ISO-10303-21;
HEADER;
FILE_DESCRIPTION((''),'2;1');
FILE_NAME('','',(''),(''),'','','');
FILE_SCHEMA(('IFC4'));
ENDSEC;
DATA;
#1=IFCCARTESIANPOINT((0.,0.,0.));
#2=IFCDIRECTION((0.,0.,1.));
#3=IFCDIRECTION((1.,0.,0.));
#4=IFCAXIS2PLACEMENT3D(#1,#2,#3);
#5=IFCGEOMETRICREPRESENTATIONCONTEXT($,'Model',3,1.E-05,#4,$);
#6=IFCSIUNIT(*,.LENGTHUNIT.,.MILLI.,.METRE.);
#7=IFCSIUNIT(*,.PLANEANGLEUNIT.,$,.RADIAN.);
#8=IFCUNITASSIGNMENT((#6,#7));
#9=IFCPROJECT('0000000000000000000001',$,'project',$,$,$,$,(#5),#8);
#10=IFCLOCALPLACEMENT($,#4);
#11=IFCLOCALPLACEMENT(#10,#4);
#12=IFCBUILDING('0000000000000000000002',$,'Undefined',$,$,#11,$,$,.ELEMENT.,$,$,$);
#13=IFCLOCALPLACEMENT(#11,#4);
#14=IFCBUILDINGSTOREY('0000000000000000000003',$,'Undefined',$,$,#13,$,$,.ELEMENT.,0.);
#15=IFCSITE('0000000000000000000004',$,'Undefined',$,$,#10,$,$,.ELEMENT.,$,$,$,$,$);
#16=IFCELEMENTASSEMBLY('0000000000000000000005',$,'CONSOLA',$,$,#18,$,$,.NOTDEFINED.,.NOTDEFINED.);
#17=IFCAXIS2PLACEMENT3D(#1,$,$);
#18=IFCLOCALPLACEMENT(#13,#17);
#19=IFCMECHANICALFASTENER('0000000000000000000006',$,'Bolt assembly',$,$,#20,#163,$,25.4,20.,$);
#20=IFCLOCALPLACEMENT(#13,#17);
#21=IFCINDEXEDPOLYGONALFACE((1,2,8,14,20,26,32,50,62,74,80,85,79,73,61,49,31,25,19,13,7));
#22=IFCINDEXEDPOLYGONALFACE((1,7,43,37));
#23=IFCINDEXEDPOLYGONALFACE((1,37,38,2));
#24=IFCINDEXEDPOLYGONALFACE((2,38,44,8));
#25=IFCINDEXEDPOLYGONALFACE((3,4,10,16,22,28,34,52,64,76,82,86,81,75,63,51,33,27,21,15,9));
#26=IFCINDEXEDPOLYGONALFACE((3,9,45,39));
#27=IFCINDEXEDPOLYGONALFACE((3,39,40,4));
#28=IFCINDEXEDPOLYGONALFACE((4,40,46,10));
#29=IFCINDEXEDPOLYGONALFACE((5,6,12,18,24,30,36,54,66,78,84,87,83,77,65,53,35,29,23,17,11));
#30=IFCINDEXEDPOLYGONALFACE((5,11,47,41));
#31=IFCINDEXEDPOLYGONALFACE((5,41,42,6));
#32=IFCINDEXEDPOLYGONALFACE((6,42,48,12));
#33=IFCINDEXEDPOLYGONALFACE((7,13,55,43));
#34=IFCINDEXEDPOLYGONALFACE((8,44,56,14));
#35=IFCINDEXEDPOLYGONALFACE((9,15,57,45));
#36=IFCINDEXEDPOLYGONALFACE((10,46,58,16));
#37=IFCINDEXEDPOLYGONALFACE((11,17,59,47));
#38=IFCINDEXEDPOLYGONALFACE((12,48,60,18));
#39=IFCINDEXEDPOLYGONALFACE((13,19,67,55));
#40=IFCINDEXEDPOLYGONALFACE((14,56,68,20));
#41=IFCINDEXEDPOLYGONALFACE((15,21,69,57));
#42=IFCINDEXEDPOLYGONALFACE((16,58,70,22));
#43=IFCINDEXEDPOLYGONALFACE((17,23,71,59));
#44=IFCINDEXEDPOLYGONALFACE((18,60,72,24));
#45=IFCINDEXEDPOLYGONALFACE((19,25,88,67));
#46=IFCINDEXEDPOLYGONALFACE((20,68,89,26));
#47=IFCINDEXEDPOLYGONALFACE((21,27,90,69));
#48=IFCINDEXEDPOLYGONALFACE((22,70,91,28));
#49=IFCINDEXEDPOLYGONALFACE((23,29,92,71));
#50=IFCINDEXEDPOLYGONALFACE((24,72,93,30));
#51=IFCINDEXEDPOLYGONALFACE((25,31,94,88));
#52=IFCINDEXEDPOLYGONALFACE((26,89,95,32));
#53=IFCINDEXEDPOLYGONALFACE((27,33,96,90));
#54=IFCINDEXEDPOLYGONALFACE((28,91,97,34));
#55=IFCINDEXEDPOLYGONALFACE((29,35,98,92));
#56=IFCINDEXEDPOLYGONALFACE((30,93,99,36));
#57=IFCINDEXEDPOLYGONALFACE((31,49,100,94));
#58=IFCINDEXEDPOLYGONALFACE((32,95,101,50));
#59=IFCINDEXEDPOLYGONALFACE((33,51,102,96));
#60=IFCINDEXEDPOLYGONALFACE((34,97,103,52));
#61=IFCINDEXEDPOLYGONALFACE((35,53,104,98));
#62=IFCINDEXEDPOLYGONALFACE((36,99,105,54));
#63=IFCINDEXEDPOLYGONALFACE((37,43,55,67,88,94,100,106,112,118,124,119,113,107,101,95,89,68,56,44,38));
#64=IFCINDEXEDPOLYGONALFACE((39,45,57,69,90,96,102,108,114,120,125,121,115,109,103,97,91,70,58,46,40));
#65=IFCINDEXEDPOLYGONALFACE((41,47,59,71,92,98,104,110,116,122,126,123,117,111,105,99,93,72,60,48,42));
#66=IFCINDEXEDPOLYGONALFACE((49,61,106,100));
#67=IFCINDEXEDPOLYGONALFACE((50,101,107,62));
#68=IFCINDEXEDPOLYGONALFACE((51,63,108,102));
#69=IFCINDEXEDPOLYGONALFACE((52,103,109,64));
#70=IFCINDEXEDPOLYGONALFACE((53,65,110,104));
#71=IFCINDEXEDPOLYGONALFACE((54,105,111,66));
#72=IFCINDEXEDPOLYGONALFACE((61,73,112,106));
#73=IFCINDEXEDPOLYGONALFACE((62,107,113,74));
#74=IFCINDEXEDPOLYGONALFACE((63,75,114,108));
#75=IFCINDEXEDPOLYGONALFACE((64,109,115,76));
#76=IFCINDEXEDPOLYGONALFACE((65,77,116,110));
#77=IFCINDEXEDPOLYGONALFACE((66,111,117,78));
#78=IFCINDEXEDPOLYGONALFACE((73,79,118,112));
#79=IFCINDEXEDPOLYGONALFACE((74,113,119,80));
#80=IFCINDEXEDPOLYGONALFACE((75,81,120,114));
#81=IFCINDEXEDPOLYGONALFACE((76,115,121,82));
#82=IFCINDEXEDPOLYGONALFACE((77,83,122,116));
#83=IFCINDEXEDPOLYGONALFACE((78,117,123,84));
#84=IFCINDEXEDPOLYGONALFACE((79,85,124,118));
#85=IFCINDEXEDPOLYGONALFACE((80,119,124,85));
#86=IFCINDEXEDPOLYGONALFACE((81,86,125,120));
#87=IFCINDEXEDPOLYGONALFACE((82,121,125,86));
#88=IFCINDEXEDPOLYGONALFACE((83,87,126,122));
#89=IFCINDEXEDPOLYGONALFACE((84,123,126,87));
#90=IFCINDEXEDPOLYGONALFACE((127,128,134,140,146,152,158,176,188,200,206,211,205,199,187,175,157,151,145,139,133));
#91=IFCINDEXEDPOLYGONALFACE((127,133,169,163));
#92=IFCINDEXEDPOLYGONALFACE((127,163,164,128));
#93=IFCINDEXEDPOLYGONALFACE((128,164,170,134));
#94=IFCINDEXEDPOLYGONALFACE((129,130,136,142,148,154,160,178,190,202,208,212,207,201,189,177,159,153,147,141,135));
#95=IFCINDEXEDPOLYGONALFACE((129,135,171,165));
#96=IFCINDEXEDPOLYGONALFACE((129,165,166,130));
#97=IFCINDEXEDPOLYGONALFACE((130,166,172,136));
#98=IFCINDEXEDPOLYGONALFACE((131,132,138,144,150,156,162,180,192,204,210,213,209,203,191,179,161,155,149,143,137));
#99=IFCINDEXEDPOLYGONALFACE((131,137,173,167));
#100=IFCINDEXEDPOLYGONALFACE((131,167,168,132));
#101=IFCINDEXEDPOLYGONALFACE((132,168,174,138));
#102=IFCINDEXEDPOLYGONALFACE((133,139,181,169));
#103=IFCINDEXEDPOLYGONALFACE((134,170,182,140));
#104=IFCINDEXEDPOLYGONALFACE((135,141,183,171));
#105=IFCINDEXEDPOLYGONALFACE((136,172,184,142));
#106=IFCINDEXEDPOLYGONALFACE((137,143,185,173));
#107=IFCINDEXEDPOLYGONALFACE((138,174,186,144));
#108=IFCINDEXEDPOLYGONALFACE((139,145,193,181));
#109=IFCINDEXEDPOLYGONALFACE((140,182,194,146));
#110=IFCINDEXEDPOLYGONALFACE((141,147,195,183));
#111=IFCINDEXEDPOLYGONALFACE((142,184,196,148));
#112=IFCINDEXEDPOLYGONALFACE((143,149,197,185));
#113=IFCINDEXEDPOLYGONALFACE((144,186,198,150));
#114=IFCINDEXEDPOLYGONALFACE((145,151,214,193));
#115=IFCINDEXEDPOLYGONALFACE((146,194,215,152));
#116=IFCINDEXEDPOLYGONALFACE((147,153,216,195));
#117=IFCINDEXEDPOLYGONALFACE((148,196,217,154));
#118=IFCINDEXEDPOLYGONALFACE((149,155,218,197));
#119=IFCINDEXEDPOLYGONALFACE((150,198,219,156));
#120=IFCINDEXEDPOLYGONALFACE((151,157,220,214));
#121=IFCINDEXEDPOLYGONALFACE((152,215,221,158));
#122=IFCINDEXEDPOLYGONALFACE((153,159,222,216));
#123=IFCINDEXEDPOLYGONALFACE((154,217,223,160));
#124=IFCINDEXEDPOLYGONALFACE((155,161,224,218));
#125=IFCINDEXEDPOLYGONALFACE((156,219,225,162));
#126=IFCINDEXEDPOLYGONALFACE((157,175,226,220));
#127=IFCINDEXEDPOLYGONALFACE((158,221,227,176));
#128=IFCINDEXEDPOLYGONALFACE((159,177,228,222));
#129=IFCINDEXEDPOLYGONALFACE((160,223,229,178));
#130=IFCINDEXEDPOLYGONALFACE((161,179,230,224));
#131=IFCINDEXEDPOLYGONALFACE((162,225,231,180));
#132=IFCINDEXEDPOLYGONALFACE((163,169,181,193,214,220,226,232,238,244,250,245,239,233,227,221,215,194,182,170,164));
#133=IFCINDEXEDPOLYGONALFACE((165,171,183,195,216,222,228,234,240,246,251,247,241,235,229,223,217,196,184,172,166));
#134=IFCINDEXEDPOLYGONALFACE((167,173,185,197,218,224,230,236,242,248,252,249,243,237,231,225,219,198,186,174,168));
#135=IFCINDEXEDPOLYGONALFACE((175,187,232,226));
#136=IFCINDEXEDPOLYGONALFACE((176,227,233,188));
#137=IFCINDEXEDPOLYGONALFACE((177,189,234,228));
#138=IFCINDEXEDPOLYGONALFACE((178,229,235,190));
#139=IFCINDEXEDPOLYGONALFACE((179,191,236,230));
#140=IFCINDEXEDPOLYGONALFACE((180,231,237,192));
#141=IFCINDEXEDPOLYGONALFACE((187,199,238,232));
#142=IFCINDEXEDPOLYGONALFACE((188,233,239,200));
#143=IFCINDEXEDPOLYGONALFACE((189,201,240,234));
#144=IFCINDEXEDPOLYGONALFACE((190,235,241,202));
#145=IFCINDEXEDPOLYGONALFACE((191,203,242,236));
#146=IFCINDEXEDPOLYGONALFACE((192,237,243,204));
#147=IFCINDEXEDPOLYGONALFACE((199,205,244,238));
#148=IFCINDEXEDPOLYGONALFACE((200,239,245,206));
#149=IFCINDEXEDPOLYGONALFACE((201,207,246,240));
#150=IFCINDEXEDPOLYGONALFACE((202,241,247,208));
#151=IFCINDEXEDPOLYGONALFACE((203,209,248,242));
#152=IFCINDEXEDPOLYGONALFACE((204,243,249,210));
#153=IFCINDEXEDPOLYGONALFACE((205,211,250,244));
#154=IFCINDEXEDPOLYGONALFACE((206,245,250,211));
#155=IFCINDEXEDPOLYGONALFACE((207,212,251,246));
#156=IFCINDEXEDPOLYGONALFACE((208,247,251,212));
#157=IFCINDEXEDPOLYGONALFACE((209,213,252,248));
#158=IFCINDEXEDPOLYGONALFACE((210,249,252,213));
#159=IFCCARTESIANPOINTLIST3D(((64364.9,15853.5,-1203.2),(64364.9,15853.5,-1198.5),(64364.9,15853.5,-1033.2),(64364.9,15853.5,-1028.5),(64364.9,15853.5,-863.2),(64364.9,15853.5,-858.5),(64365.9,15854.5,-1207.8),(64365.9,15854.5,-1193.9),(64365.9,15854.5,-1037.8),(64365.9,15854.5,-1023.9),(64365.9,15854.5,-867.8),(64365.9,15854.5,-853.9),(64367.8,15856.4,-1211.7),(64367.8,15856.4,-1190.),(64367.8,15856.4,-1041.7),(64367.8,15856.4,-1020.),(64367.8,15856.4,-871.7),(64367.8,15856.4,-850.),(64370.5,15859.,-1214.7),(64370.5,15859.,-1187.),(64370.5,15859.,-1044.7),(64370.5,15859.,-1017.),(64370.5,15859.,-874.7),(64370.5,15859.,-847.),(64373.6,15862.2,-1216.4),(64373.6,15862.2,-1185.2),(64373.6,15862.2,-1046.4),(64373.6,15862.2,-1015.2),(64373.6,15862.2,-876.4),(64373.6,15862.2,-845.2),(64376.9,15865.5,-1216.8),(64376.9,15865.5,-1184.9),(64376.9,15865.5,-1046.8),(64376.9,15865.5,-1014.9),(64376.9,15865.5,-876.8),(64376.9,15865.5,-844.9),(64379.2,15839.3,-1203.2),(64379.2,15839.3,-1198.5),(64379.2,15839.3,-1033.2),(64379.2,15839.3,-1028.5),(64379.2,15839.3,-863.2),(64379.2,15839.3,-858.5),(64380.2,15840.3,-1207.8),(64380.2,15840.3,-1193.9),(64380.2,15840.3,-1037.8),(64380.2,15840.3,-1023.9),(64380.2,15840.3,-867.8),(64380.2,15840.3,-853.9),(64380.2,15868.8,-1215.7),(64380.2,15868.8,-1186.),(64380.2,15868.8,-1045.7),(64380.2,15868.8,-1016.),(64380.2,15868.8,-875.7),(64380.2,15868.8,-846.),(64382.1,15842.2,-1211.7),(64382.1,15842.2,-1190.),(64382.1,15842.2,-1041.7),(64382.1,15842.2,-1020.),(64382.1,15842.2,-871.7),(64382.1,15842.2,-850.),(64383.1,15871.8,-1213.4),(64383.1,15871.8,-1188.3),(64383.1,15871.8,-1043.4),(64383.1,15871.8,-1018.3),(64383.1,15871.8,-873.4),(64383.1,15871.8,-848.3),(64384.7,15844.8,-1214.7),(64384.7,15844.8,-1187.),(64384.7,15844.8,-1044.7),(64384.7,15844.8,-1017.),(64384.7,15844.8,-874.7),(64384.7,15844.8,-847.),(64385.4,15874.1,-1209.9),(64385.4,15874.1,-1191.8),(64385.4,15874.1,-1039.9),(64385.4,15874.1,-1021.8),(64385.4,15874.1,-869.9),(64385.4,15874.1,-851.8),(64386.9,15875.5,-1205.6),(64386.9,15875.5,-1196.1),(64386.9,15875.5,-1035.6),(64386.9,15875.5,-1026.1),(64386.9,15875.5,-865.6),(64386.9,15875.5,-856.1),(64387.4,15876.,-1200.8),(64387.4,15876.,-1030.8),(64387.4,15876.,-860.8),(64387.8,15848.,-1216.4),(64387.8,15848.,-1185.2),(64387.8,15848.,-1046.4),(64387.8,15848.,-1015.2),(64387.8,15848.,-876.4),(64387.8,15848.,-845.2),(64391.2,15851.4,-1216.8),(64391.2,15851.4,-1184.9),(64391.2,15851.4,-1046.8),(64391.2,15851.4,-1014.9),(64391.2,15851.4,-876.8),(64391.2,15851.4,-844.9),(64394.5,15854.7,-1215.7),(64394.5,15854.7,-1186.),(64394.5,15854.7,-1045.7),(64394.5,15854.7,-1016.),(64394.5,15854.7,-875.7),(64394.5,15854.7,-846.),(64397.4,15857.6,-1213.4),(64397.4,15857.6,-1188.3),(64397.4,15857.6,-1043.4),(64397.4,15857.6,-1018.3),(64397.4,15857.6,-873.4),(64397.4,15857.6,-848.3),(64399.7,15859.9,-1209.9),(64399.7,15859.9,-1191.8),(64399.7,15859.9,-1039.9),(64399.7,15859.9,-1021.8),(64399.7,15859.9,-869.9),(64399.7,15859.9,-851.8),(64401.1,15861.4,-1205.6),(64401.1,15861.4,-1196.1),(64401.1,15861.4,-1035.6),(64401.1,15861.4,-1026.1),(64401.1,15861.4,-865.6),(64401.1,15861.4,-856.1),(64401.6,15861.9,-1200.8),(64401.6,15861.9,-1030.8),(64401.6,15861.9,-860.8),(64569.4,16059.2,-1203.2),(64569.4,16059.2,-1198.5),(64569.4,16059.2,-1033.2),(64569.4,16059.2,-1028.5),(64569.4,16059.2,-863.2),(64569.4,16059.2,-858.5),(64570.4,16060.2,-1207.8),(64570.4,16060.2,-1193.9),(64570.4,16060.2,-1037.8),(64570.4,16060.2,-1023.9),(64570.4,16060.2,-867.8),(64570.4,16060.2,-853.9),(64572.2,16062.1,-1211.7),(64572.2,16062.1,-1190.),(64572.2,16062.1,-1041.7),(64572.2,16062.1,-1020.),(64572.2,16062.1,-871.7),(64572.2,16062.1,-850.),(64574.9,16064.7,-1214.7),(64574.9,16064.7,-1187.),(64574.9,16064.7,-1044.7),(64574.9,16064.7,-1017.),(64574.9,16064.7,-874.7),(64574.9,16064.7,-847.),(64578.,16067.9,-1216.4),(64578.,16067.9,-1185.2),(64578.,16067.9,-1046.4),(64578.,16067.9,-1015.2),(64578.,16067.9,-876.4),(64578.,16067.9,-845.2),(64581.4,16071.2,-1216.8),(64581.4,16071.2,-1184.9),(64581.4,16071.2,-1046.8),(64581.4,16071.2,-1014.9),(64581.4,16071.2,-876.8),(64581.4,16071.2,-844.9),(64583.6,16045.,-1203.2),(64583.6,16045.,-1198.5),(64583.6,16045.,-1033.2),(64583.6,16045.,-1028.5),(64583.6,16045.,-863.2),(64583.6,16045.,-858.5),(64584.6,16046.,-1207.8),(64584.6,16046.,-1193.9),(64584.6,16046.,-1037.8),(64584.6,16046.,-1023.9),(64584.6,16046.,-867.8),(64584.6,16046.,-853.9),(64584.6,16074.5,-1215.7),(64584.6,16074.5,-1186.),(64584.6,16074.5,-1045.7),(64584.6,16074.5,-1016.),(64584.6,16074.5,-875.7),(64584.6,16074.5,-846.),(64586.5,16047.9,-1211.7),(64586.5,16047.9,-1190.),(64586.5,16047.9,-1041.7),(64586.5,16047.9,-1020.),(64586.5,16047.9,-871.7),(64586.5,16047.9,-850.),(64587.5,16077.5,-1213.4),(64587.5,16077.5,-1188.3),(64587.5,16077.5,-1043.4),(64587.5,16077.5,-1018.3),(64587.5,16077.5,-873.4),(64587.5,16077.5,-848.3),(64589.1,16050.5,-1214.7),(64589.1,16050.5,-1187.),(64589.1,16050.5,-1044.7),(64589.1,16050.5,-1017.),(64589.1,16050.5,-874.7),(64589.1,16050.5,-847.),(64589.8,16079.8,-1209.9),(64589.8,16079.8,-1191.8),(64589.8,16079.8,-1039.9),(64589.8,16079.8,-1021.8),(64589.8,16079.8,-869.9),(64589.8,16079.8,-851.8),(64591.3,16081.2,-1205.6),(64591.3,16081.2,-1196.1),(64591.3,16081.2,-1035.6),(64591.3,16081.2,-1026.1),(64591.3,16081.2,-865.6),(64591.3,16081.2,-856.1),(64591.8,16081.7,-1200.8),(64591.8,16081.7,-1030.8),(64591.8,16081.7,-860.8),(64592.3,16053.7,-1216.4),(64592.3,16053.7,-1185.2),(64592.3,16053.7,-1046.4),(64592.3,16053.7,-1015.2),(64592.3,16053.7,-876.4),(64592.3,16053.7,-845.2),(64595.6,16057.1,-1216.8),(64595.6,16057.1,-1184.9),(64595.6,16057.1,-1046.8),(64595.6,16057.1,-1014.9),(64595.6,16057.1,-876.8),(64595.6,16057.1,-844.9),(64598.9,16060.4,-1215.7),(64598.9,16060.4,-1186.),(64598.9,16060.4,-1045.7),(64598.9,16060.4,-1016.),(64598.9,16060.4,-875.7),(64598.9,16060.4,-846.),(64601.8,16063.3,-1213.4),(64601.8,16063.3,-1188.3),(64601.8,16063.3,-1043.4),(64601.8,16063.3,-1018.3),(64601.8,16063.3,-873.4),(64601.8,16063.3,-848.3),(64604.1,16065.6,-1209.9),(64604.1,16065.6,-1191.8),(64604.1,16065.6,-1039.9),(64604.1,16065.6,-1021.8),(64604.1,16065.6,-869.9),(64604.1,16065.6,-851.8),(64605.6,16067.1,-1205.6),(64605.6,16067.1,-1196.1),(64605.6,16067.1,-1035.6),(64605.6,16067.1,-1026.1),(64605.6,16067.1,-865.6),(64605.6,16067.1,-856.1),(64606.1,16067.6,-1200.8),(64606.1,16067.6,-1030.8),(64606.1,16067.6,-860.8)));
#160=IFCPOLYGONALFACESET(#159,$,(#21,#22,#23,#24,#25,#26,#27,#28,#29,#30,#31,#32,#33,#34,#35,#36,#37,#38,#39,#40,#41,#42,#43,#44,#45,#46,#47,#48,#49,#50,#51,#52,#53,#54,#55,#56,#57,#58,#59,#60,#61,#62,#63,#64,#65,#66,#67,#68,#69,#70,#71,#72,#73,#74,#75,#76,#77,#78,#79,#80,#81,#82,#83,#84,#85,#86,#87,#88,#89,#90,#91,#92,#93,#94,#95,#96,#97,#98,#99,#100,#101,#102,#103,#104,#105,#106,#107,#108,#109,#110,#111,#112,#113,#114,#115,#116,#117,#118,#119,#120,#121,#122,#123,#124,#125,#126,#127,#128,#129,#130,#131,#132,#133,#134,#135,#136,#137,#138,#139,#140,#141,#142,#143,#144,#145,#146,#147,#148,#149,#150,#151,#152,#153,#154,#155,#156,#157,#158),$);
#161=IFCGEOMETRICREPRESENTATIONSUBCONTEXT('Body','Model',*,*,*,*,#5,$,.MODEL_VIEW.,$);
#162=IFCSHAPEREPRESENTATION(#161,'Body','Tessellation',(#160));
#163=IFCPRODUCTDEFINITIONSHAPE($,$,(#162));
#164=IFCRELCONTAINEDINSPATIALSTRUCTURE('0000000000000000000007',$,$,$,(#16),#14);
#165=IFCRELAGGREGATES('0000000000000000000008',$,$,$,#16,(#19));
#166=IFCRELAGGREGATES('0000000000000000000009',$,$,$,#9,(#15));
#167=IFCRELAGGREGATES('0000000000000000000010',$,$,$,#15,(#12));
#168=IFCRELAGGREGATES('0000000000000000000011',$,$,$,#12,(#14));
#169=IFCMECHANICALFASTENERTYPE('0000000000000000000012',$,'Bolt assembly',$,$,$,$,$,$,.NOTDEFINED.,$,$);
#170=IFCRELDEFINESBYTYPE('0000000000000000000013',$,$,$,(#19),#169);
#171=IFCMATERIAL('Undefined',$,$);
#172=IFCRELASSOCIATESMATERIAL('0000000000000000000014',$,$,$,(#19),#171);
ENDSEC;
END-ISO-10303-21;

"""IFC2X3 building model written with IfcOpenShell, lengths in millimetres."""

from ifc_helpers import new_model, si_unit, frame, origin_with_axes, origin_2d_with_axis, place, context, subcontext, project, spatial, circle, extrude, source, transform, mapped, material, type_object, element, aggregate, save


model = new_model("IFC2X3")

# Units and contexts
model_context = context("Model", 3, precision=1e-05, world=origin_with_axes())
body_context = subcontext(model_context, "Body", "Model", "MODEL_VIEW")
ifc_project = project(units=[si_unit("LENGTHUNIT", "METRE", prefix="MILLI"), si_unit("PLANEANGLEUNIT", "RADIAN")], contexts=[model_context])

# Site, building, storey
site_placement = place(None, origin_with_axes())
site = spatial("IfcSite", under=ifc_project, at=site_placement, Name="Undefined", CompositionType="ELEMENT")
building_placement = place(site_placement, origin_with_axes())
building = spatial("IfcBuilding", under=site, at=building_placement, Name="Undefined", CompositionType="ELEMENT")
storey_placement = place(building_placement, origin_with_axes())
storey = spatial("IfcBuildingStorey", under=building, at=storey_placement, Name="Undefined", CompositionType="ELEMENT", Elevation=0.0)

# Element assembly
assembly_1_placement = place(storey_placement, origin_with_axes())
assembly_1 = element("IfcElementAssembly", 1, at=assembly_1_placement, inside=storey, Name="CONSOLA", AssemblyPlace="NOTDEFINED", PredefinedType="NOTDEFINED")

# Mechanical fastener
ifc_material_1 = material(Name="Undefined")
mechanical_fastener_type = type_object("IfcMechanicalFastenerType", Name="Bolt assembly")
shared_shape_1 = source(origin_with_axes(), body_context, "Body", "SweptSolid", [
    extrude(circle(Radius=16.0, at=origin_2d_with_axis()), frame((0.0, -4.0, 0.0), z_axis=(0.0, 1.0, 0.0), x_axis=(1.0, 0.0, 0.0)), (0.0, 0.0, 1.0), 20.1),
])
mechanical_fastener_1_placement = place(assembly_1_placement, frame((64387.5, 15853.3, -1030.8), z_axis=(0.000001, 0.000001, 1.0), x_axis=(0.704896, 0.709311, -0.000002)))
mechanical_fastener_1 = element("IfcMechanicalFastener", 2, at=mechanical_fastener_1_placement, type_object=mechanical_fastener_type, material=ifc_material_1, Name="Bolt assembly", NominalDiameter=25.4, NominalLength=20.0, context=body_context, shape_type="MappedRepresentation", body=[
    mapped(shared_shape_1, transform((0.0, 0.0, -170.0))),
    mapped(shared_shape_1, transform((290.0, 0.0, -170.0))),
    mapped(shared_shape_1, transform((0.0, 0.0, 0.0))),
    mapped(shared_shape_1, transform((290.0, 0.0, 0.0))),
    mapped(shared_shape_1, transform((0.0, 0.0, 170.0))),
    mapped(shared_shape_1, transform((290.0, 0.0, 170.0))),
])
aggregate(assembly_1, [mechanical_fastener_1])

save(model, "model.ifc")
